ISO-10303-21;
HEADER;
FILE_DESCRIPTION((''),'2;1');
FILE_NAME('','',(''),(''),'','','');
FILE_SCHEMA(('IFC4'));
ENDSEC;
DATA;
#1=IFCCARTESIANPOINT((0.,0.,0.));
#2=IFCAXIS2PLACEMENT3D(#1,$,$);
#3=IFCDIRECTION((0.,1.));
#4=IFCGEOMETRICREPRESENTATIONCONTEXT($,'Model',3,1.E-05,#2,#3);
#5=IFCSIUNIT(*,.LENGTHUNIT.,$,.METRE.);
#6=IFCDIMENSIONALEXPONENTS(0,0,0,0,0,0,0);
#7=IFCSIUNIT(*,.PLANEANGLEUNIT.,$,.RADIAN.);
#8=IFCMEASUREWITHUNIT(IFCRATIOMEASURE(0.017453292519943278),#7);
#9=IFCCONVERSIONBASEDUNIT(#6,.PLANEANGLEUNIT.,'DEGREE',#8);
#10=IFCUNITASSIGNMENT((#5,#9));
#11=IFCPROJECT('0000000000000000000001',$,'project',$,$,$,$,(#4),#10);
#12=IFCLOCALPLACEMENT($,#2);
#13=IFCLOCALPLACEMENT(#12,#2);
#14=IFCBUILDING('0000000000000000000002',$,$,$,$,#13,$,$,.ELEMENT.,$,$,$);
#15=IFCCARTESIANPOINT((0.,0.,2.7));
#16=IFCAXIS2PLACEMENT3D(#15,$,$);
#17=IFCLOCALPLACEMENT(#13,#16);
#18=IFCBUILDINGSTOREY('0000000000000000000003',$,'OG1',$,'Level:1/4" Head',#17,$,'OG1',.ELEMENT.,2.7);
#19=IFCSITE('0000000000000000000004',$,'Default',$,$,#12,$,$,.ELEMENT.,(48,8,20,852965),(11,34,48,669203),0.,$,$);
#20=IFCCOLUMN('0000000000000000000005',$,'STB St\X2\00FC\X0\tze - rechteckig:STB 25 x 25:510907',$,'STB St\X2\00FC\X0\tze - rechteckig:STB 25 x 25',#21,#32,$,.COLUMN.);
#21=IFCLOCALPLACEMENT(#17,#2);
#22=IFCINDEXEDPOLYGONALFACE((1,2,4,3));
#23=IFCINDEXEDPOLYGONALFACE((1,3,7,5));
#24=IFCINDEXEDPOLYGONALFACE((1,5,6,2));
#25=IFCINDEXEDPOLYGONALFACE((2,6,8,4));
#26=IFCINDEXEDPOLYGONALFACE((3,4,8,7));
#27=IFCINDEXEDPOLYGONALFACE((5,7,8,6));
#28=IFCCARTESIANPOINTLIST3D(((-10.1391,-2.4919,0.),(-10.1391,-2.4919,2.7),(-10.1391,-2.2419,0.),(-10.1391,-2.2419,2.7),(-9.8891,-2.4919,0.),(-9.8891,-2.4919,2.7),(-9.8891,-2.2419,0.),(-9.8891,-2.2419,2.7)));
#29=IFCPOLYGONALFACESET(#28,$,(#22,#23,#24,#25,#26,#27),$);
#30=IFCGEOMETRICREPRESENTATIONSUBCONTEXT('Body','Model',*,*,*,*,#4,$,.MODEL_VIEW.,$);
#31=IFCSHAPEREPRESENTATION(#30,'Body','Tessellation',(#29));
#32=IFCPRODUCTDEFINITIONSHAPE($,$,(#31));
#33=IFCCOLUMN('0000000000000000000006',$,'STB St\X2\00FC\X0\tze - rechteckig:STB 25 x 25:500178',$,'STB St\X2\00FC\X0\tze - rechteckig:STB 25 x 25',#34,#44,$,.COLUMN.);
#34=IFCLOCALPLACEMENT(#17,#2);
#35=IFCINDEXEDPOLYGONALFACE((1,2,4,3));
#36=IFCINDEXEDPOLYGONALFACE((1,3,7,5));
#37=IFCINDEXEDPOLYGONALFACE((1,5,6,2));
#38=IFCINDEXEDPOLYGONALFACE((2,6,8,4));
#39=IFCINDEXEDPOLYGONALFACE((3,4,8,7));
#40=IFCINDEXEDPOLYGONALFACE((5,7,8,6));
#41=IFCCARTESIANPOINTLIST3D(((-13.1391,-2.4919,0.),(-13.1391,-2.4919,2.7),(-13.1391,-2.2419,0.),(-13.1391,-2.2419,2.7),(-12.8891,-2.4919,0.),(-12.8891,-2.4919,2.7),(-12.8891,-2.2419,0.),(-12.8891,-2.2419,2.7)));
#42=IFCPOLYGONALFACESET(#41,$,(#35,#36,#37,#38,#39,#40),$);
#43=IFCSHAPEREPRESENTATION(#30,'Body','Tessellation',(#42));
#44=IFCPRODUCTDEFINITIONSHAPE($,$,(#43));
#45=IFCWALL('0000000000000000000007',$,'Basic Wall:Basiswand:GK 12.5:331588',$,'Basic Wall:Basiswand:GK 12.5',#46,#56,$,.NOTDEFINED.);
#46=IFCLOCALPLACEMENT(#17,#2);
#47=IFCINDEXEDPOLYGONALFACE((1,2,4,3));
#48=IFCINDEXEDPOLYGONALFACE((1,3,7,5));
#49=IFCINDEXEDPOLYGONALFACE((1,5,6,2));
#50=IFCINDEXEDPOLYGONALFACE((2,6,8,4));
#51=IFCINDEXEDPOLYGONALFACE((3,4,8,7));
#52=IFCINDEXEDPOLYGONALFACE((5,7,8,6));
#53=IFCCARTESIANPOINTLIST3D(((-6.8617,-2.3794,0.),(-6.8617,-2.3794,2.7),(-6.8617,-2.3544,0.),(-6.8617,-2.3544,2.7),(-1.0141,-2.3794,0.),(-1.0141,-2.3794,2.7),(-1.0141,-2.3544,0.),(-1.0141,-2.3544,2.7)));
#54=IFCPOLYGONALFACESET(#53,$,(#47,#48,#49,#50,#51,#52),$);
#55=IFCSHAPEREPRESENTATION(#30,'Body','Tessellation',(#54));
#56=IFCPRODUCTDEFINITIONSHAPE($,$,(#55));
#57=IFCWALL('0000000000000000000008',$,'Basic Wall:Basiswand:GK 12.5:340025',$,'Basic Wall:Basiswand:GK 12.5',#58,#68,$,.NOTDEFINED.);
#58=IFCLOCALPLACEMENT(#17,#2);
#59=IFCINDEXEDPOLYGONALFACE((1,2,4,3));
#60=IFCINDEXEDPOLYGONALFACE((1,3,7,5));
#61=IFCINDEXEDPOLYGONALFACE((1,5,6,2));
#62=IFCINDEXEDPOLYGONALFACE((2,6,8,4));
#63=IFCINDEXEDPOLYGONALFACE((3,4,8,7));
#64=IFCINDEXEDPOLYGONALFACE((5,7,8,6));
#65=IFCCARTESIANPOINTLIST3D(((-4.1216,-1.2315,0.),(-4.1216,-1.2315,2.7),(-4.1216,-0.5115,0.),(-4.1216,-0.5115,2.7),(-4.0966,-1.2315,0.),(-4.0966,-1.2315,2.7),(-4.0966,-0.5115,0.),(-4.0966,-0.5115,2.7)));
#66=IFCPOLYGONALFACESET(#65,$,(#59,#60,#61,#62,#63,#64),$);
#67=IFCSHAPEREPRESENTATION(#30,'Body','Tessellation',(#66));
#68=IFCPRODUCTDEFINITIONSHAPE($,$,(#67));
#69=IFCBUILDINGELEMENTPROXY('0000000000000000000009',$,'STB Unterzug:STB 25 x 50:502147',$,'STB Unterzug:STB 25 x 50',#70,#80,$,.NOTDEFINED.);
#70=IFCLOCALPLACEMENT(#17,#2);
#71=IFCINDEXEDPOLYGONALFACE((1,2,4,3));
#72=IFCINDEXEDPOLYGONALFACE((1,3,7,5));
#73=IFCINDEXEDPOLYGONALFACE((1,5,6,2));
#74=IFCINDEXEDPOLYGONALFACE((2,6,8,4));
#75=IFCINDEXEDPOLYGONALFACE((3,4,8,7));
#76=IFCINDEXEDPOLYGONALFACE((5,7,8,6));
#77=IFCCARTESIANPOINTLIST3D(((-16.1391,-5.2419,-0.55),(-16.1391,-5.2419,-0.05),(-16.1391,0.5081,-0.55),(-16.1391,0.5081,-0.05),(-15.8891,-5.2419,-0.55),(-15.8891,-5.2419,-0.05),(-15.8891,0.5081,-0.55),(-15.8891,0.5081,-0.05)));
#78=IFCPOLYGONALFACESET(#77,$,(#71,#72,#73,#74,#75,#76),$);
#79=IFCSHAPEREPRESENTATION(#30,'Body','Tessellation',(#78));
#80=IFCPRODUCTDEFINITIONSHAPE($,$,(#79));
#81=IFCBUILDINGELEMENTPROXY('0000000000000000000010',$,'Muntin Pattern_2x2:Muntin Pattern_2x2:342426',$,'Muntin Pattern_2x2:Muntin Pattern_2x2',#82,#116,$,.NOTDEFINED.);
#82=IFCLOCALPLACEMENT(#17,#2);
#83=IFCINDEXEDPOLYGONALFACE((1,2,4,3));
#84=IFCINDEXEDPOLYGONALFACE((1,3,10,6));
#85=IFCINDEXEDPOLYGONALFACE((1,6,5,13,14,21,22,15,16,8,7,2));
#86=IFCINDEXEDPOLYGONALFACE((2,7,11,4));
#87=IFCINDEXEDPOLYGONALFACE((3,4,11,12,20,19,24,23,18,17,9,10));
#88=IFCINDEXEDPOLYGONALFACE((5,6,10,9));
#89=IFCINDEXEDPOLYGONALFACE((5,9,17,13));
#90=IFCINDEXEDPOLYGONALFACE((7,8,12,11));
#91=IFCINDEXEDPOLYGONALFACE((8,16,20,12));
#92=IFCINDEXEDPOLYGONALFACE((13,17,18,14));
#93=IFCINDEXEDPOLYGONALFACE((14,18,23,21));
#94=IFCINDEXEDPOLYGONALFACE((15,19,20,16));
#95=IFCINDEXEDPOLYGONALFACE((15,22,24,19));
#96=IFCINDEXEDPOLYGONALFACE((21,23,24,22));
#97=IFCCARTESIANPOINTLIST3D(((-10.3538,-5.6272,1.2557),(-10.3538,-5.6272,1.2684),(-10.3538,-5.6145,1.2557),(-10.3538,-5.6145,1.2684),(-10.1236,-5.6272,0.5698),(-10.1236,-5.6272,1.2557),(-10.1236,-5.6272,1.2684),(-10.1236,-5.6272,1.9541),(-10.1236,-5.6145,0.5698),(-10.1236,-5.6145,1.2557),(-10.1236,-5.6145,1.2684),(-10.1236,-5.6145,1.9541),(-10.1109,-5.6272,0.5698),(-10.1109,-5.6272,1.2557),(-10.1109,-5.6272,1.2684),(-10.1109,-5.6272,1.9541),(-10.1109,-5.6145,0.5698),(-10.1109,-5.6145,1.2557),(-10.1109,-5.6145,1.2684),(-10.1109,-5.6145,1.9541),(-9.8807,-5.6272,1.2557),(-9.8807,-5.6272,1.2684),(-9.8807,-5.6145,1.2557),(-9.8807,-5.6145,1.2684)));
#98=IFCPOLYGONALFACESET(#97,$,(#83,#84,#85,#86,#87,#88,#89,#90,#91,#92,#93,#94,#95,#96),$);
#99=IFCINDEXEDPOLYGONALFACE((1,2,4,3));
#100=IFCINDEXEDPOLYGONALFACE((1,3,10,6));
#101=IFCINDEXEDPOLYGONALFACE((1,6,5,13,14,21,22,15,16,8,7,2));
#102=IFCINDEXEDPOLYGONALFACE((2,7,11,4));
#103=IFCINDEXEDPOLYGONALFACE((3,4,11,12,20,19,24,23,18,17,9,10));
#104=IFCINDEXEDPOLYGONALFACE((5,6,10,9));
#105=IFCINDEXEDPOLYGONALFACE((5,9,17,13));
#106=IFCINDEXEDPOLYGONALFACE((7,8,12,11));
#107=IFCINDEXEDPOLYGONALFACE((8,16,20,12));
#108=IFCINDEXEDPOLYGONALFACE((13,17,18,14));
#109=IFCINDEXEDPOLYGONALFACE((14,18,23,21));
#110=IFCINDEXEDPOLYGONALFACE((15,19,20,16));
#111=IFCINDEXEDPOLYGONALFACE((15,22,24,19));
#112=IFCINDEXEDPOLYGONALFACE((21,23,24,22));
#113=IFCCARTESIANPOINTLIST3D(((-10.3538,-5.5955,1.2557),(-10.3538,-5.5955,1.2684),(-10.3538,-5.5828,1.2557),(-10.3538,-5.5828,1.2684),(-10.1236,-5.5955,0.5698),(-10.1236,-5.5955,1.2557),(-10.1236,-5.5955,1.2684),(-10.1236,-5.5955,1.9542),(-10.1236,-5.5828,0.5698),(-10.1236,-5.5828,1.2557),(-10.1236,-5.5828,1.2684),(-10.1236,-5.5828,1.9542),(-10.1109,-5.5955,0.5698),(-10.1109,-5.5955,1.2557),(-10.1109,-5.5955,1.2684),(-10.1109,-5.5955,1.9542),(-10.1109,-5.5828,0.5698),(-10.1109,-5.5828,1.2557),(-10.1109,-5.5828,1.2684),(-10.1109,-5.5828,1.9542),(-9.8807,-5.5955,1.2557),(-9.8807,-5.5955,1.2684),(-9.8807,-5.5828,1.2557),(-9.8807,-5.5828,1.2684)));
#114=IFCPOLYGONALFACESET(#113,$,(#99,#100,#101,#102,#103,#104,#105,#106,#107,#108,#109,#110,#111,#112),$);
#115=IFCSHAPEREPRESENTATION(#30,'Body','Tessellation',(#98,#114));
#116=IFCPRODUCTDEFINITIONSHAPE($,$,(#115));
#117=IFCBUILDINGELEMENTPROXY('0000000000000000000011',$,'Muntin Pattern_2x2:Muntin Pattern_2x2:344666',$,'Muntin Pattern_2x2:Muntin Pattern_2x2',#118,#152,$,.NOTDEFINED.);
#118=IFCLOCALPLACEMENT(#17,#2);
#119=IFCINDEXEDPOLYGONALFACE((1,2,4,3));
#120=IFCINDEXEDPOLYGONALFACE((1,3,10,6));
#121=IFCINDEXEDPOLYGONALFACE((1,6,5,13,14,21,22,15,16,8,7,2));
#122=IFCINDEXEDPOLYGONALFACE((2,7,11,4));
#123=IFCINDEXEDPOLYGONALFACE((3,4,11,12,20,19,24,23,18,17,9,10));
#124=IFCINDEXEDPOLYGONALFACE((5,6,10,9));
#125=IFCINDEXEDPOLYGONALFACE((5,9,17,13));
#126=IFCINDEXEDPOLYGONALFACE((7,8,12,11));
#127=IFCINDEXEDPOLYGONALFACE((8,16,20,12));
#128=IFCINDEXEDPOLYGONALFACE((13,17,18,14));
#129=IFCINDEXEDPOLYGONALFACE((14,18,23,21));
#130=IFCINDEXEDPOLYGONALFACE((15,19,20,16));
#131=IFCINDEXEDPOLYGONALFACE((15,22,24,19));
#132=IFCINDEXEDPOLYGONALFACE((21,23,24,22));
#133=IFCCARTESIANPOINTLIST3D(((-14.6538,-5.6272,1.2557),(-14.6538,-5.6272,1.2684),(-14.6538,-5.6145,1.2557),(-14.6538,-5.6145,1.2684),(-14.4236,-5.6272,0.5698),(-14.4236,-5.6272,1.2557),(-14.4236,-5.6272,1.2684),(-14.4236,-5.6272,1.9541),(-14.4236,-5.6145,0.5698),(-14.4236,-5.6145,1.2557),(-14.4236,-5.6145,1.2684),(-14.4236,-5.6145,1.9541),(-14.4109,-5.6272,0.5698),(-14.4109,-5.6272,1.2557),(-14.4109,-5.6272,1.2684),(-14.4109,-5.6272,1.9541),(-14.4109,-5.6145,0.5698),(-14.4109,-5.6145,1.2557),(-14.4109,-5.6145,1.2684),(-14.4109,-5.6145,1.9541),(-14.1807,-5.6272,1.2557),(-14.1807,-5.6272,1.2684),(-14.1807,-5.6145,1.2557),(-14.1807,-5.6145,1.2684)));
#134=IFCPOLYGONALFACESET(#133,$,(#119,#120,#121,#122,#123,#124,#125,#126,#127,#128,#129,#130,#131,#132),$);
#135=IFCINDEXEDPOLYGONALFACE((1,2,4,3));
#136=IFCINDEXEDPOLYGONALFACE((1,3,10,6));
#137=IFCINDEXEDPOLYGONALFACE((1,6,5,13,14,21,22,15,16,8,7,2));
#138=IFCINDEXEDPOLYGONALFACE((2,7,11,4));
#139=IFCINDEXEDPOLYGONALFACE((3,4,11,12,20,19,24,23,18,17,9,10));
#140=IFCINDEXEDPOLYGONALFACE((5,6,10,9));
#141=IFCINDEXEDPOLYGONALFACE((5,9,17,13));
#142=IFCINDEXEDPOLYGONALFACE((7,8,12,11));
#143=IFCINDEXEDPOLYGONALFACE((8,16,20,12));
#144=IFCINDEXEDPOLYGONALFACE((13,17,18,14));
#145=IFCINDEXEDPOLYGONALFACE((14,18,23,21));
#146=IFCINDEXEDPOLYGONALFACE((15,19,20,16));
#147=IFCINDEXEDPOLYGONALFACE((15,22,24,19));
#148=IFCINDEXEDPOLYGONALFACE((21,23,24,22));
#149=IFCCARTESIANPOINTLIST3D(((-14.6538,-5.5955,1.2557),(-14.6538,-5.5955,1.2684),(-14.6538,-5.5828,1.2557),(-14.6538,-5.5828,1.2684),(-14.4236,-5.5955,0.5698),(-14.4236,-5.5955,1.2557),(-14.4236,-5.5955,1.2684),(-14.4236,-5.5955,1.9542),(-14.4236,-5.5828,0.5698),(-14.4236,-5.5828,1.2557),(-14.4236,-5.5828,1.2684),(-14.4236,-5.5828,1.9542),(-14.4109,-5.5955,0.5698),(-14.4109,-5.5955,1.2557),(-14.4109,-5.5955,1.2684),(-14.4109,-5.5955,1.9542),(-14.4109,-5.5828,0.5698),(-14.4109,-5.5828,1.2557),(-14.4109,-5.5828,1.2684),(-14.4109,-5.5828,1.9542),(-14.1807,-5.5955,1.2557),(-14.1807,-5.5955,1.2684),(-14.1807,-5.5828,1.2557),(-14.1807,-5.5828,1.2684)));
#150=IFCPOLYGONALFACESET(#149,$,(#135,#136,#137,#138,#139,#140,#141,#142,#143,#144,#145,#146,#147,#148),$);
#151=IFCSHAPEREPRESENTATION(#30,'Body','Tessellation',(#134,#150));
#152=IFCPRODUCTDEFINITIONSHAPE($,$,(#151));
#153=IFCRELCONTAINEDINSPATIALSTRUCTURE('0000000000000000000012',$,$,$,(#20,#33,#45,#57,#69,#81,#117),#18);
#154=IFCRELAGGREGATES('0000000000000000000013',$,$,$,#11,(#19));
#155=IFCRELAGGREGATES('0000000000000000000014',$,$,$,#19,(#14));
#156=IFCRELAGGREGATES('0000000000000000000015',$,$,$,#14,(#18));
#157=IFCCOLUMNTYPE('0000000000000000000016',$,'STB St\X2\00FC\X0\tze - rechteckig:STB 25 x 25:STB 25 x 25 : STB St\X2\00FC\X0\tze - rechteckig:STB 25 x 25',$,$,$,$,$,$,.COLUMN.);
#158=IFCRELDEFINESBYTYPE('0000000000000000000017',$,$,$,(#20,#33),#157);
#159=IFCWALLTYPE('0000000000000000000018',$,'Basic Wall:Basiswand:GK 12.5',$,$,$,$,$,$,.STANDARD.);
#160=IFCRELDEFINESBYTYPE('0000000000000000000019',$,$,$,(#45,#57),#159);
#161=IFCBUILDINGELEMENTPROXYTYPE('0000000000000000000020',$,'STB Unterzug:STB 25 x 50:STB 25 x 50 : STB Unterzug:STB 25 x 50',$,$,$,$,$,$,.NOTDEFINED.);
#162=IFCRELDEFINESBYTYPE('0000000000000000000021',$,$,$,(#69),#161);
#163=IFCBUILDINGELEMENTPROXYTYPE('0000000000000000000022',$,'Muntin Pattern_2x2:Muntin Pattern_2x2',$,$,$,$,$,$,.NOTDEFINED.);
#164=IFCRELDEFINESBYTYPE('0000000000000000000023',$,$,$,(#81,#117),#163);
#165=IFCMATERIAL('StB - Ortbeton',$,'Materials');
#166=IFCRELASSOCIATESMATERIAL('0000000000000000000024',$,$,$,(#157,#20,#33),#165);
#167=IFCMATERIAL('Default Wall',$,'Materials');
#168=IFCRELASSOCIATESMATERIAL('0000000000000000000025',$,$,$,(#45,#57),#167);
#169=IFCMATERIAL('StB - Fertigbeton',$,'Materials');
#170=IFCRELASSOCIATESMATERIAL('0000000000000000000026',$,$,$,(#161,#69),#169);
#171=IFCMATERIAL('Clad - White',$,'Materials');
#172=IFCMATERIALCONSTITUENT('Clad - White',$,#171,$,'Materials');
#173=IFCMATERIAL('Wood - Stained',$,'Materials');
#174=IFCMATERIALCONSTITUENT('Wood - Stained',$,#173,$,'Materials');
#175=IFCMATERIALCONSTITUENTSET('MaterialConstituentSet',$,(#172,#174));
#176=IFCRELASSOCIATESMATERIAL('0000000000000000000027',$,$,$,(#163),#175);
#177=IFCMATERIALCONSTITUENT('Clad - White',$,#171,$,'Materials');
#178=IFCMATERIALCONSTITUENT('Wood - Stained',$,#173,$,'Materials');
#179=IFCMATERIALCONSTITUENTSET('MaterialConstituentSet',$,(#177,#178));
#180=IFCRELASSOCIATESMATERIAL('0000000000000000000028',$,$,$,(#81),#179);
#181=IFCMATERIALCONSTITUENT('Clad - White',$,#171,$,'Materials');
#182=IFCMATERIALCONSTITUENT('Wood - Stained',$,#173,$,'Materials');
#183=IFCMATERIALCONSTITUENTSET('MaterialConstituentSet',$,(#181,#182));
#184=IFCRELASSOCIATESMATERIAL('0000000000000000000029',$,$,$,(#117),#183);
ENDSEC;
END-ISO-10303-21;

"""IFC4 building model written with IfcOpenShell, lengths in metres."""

from ifc_helpers import new_model, entity, si_unit, converted_unit, direction, frame, origin, place, context, subcontext, project, spatial, indexed_curve, outline, extrude, source, transform, mapped, material, constituent, constituent_set, type_object, type_shapes, element, save


model = new_model("IFC4")

# Units and contexts
model_context = context("Model", 3, precision=1e-05, world=origin(), true_north=direction((0.0, 1.0)))
body_context = subcontext(model_context, "Body", "Model", "MODEL_VIEW")
ifc_project = project(units=[si_unit("LENGTHUNIT", "METRE"), converted_unit("PLANEANGLEUNIT", "DEGREE", entity("IfcRatioMeasure", 0.017453292519943278), si_unit("PLANEANGLEUNIT", "RADIAN"), dimensions=[0, 0, 0, 0, 0, 0, 0])], contexts=[model_context])

# Site, building, storey
site_placement = place(None, origin())
site = spatial("IfcSite", under=ifc_project, at=site_placement, Name="Default", CompositionType="ELEMENT", RefLatitude=(48, 8, 20, 852965), RefLongitude=(11, 34, 48, 669203), RefElevation=0.0)
building_placement = place(site_placement, origin())
building = spatial("IfcBuilding", under=site, at=building_placement, CompositionType="ELEMENT")
storey_placement = place(building_placement, frame((0.0, 0.0, 2.7)))
storey = spatial("IfcBuildingStorey", under=building, at=storey_placement, Name="OG1", ObjectType="Level:1/4\" Head", LongName="OG1", CompositionType="ELEMENT", Elevation=2.7)

# Columns
ifc_material_1 = material(Name="StB - Ortbeton", Category="Materials")
column_type = type_object("IfcColumnType", Name="STB Stütze - rechteckig:STB 25 x 25:STB 25 x 25 : STB Stütze - rechteckig:STB 25 x 25", PredefinedType="COLUMN", material=ifc_material_1)
shared_shape_1 = source(origin(), body_context, "Body", "SweptSolid", [
    extrude(outline(indexed_curve([(-0.125, -0.125), (0.125, -0.125), (0.125, 0.125), (-0.125, 0.125), (-0.125, -0.125)], self_intersect=False)), frame((0.0, 0.0, 2.7), z_axis=(0.0, 0.0, 1.0), x_axis=(0.0, -1.0, 0.0)), (0.0, 0.0, 1.0), 2.7),
])
type_shapes(column_type, [shared_shape_1])
for number, where, name in (
    (1, (-10.0141, -2.3669, -2.7), "STB Stütze - rechteckig:STB 25 x 25:510907"),
    (2, (-13.0141, -2.3669, -2.7), "STB Stütze - rechteckig:STB 25 x 25:500178"),
):
    element("IfcColumn", number, at=place(storey_placement, frame(where)), inside=storey, type_object=column_type, material=ifc_material_1, Name=name, ObjectType="STB Stütze - rechteckig:STB 25 x 25", PredefinedType="COLUMN", context=body_context, shape_type="MappedRepresentation", body=[
        mapped(shared_shape_1, transform((0.0, 0.0, 0.0), scale=1.0)),
    ])

# Walls
ifc_material_2 = material(Name="Default Wall", Category="Materials")
wall_type_1 = type_object("IfcWallType", Name="Basic Wall:Basiswand:GK 12.5", PredefinedType="STANDARD")
wall_1_placement = place(storey_placement, frame((-6.8617, -2.3669, 0.0)))
element("IfcWall", 3, at=wall_1_placement, inside=storey, type_object=wall_type_1, material=ifc_material_2, Name="Basic Wall:Basiswand:GK 12.5:331588", ObjectType="Basic Wall:Basiswand:GK 12.5", PredefinedType="NOTDEFINED", context=body_context, shape_type="SweptSolid", body=[
    extrude(outline(indexed_curve([(5.8476, 0.0125), (0.0, 0.0125), (0.0, -0.0125), (5.8476, -0.0125), (5.8476, 0.0125)], self_intersect=False)), origin(), (0.0, 0.0, 1.0), 2.7),
])
wall_2_placement = place(storey_placement, frame((-4.1091, -0.5115, 0.0), z_axis=(0.0, 0.0, 1.0), x_axis=(0.0, -1.0, 0.0)))
element("IfcWall", 4, at=wall_2_placement, inside=storey, type_object=wall_type_1, material=ifc_material_2, Name="Basic Wall:Basiswand:GK 12.5:340025", ObjectType="Basic Wall:Basiswand:GK 12.5", PredefinedType="NOTDEFINED", context=body_context, shape_type="SweptSolid", body=[
    extrude(outline(indexed_curve([(0.72, 0.0125), (0.0, 0.0125), (0.0, -0.0125), (0.72, -0.0125), (0.72, 0.0125)], self_intersect=False)), origin(), (0.0, 0.0, 1.0), 2.7),
])

# Building element proxies
ifc_material_3 = material(Name="StB - Fertigbeton", Category="Materials")
building_element_proxy_type_1 = type_object("IfcBuildingElementProxyType", Name="STB Unterzug:STB 25 x 50:STB 25 x 50 : STB Unterzug:STB 25 x 50", PredefinedType="NOTDEFINED", material=ifc_material_3)
shared_shape_2 = source(origin(), body_context, "Body", "SweptSolid", [
    extrude(outline(indexed_curve([(-2.875, -0.125), (2.875, -0.125), (2.875, 0.125), (-2.875, 0.125), (-2.875, -0.125)], self_intersect=False)), frame((0.0, 0.0, -0.25), z_axis=(0.0, 0.0, 1.0), x_axis=(-1.0, 0.0, 0.0)), (0.0, 0.0, 1.0), 0.5),
])
type_shapes(building_element_proxy_type_1, [shared_shape_2])
proxy_1_placement = place(storey_placement, frame((-16.0141, -2.3669, -0.3), z_axis=(0.0, 0.0, 1.0), x_axis=(0.0, 1.0, 0.0)))
element("IfcBuildingElementProxy", 5, at=proxy_1_placement, inside=storey, type_object=building_element_proxy_type_1, material=ifc_material_3, Name="STB Unterzug:STB 25 x 50:502147", ObjectType="STB Unterzug:STB 25 x 50", PredefinedType="NOTDEFINED", context=body_context, shape_type="MappedRepresentation", body=[
    mapped(shared_shape_2, transform((0.0, 0.0, 0.0), scale=1.0)),
])
ifc_material_4 = material(Name="Clad - White", Category="Materials")
ifc_constituent_1 = constituent(ifc_material_4, Name="Clad - White", Category="Materials")
ifc_material_5 = material(Name="Wood - Stained", Category="Materials")
ifc_constituent_2 = constituent(ifc_material_5, Name="Wood - Stained", Category="Materials")
ifc_constituent_set_1 = constituent_set(constituents=[ifc_constituent_1, ifc_constituent_2], Name="MaterialConstituentSet")
ifc_constituent_3 = constituent(ifc_material_4, Name="Clad - White", Category="Materials")
ifc_constituent_4 = constituent(ifc_material_5, Name="Wood - Stained", Category="Materials")
ifc_constituent_set_2 = constituent_set(constituents=[ifc_constituent_3, ifc_constituent_4], Name="MaterialConstituentSet")
building_element_proxy_type_2 = type_object("IfcBuildingElementProxyType", Name="Muntin Pattern_2x2:Muntin Pattern_2x2", PredefinedType="NOTDEFINED", material=ifc_constituent_set_2)
shared_shape_3 = source(origin(), body_context, "Body", "SweptSolid", [
    extrude(outline(indexed_curve([(0.0064, -0.0064), (0.6921, -0.0064), (0.6921, 0.0063), (0.0064, 0.0063), (0.0064, 0.2365), (-0.0063, 0.2365), (-0.0063, 0.0063), (-0.6922, 0.0063), (-0.6922, -0.0064), (-0.0063, -0.0064), (-0.0063, -0.2365), (0.0064, -0.2365), (0.0064, -0.0064)], self_intersect=False)), frame((0.0, -0.0222, 0.6921), z_axis=(0.0, 1.0, 0.0), x_axis=(0.0, 0.0, 1.0)), (0.0, 0.0, 1.0), 0.0127),
    extrude(outline(indexed_curve([(0.0064, -0.0064), (0.6922, -0.0064), (0.6922, 0.0063), (0.0064, 0.0063), (0.0064, 0.2365), (-0.0063, 0.2365), (-0.0063, 0.0063), (-0.6922, 0.0063), (-0.6922, -0.0064), (-0.0063, -0.0064), (-0.0063, -0.2365), (0.0064, -0.2365), (0.0064, -0.0064)], self_intersect=False)), frame((0.0, 0.0095, 0.6922), z_axis=(0.0, 1.0, 0.0), x_axis=(0.0, 0.0, 1.0)), (0.0, 0.0, 1.0), 0.0127),
])
type_shapes(building_element_proxy_type_2, [shared_shape_3])
proxy_2_placement = place(storey_placement, frame((-10.1173, -5.605, 0.5699)))
element("IfcBuildingElementProxy", 6, at=proxy_2_placement, inside=storey, type_object=building_element_proxy_type_2, material=ifc_constituent_set_1, Name="Muntin Pattern_2x2:Muntin Pattern_2x2:342426", ObjectType="Muntin Pattern_2x2:Muntin Pattern_2x2", PredefinedType="NOTDEFINED", context=body_context, shape_type="MappedRepresentation", body=[
    mapped(shared_shape_3, transform((0.0, 0.0, 0.0), scale=1.0)),
])
ifc_constituent_5 = constituent(ifc_material_4, Name="Clad - White", Category="Materials")
ifc_constituent_6 = constituent(ifc_material_5, Name="Wood - Stained", Category="Materials")
ifc_constituent_set_3 = constituent_set(constituents=[ifc_constituent_5, ifc_constituent_6], Name="MaterialConstituentSet")
proxy_3_placement = place(storey_placement, frame((-14.4173, -5.605, 0.5699)))
element("IfcBuildingElementProxy", 7, at=proxy_3_placement, inside=storey, type_object=building_element_proxy_type_2, material=ifc_constituent_set_3, Name="Muntin Pattern_2x2:Muntin Pattern_2x2:344666", ObjectType="Muntin Pattern_2x2:Muntin Pattern_2x2", PredefinedType="NOTDEFINED", context=body_context, shape_type="MappedRepresentation", body=[
    mapped(shared_shape_3, transform((0.0, 0.0, 0.0), scale=1.0)),
])

save(model, "model.ifc")
